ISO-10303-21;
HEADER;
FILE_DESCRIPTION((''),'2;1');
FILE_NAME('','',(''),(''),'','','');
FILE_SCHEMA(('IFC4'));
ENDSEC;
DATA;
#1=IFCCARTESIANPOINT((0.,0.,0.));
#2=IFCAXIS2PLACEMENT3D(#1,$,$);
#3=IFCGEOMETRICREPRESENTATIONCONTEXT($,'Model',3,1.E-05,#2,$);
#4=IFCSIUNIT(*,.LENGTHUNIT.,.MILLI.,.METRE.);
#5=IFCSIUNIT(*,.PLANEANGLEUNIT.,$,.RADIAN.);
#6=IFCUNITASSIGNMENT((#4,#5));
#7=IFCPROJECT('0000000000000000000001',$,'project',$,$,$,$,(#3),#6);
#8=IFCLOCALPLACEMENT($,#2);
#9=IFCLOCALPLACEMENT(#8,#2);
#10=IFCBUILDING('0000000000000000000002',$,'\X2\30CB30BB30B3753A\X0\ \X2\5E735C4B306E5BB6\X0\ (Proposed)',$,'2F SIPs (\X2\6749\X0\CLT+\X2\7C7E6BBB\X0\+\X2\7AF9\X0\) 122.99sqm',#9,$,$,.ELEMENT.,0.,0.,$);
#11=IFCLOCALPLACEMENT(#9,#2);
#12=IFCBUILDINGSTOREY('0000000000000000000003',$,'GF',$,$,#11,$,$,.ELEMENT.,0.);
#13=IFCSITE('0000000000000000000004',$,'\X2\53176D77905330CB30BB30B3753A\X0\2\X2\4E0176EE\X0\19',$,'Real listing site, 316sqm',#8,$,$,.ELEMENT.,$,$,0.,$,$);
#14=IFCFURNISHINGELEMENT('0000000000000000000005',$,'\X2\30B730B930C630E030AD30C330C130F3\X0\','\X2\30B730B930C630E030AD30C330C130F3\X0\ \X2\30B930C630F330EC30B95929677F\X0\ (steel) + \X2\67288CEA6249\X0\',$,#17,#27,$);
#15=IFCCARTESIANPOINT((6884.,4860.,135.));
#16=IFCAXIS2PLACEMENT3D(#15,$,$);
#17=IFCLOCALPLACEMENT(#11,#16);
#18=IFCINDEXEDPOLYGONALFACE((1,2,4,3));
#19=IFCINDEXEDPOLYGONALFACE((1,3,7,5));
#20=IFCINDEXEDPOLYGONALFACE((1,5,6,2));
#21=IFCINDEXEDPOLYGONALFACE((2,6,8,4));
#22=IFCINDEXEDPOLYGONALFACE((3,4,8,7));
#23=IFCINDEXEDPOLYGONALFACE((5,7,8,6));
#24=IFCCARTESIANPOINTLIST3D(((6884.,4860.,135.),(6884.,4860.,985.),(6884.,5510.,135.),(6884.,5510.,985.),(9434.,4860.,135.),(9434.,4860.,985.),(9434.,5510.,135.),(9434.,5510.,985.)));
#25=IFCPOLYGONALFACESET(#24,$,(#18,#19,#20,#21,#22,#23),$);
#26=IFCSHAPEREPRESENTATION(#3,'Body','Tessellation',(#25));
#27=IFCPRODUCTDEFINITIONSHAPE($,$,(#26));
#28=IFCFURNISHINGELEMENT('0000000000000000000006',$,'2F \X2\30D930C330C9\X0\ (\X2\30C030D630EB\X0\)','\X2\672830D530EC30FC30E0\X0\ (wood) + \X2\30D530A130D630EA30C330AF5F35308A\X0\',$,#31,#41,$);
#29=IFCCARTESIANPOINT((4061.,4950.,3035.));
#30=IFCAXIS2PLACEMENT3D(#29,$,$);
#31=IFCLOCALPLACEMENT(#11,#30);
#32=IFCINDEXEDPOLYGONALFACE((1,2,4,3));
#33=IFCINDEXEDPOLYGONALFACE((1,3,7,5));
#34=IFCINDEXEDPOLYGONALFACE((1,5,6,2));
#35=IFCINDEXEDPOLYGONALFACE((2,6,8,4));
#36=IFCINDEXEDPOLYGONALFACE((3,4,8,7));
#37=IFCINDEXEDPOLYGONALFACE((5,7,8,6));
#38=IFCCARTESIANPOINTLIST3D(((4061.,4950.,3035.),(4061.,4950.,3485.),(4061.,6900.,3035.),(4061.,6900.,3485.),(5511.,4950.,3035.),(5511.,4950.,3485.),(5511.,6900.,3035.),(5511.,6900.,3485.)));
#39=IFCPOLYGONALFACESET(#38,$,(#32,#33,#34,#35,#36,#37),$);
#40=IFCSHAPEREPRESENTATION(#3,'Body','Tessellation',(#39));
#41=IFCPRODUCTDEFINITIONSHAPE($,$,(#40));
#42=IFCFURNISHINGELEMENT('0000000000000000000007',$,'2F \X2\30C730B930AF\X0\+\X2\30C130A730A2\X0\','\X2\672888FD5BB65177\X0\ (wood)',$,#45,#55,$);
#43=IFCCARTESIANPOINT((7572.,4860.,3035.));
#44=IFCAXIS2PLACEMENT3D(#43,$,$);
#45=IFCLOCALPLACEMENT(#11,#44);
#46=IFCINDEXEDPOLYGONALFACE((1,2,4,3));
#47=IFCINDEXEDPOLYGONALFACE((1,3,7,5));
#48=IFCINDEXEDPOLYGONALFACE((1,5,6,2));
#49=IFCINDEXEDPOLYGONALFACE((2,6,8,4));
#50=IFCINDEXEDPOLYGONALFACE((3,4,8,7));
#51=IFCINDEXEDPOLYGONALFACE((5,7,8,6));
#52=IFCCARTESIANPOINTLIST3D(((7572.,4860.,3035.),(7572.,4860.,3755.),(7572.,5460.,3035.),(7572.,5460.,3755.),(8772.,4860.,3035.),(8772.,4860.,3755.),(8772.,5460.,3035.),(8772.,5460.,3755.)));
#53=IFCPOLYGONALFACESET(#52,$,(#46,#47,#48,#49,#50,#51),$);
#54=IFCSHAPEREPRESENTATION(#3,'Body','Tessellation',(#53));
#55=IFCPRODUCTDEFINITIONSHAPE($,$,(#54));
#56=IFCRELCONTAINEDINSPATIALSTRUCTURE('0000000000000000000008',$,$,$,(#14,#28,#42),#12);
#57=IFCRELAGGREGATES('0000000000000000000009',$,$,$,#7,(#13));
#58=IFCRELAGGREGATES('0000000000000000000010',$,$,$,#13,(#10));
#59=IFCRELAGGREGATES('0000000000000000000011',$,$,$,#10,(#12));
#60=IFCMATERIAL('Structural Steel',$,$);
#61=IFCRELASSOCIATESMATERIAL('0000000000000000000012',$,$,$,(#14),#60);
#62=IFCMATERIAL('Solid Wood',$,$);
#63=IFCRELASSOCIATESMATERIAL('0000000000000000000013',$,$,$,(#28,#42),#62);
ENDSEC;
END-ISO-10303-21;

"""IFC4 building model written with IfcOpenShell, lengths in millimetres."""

from ifc_helpers import new_model, si_unit, frame, frame_2d, origin, place, context, project, spatial, rectangle, extrude, material, element, save


model = new_model("IFC4")

# Units and contexts
model_context = context("Model", 3, precision=1e-05, world=origin())
ifc_project = project(units=[si_unit("LENGTHUNIT", "METRE", prefix="MILLI"), si_unit("PLANEANGLEUNIT", "RADIAN")], contexts=[model_context])

# Site, building, storey
site_placement = place(None, origin())
site = spatial("IfcSite", under=ifc_project, at=site_placement, Name="北海道ニセコ町2丁目19", ObjectType="Real listing site, 316sqm", CompositionType="ELEMENT", RefElevation=0.0)
building_placement = place(site_placement, origin())
building = spatial("IfcBuilding", under=site, at=building_placement, Name="ニセコ町 平屋の家 (Proposed)", ObjectType="2F SIPs (杉CLT+籾殻+竹) 122.99sqm", CompositionType="ELEMENT", ElevationOfRefHeight=0.0, ElevationOfTerrain=0.0)
storey_placement = place(building_placement, origin())
storey = spatial("IfcBuildingStorey", under=building, at=storey_placement, Name="GF", CompositionType="ELEMENT", Elevation=0.0)

# Shared definitions
ifc_material_1 = material(Name="Solid Wood")

# Furnishing elements
ifc_material_2 = material(Name="Structural Steel")
furnishing_1_placement = place(storey_placement, frame((6884.0, 4860.0, 135.0)))
element("IfcFurnishingElement", 1, at=furnishing_1_placement, inside=storey, material=ifc_material_2, Name="システムキッチン", Description="システムキッチン ステンレス天板 (steel) + 木質扉", context=model_context, shape_type="SweptSolid", body=[
    extrude(rectangle(XDim=2550.0, YDim=650.0, at=frame_2d((1275.0, 325.0))), frame((6884.0, 4860.0, 135.0)), (0.0, 0.0, 1.0), 850.0),
])
furnishing_2_placement = place(storey_placement, frame((4061.0, 4950.0, 3035.0)))
element("IfcFurnishingElement", 2, at=furnishing_2_placement, inside=storey, material=ifc_material_1, Name="2F ベッド (ダブル)", Description="木フレーム (wood) + ファブリック張り", context=model_context, shape_type="SweptSolid", body=[
    extrude(rectangle(XDim=1450.0, YDim=1950.0, at=frame_2d((725.0, 975.0))), frame((4061.0, 4950.0, 3035.0)), (0.0, 0.0, 1.0), 450.0),
])
furnishing_3_placement = place(storey_placement, frame((7572.0, 4860.0, 3035.0)))
element("IfcFurnishingElement", 3, at=furnishing_3_placement, inside=storey, material=ifc_material_1, Name="2F デスク+チェア", Description="木製家具 (wood)", context=model_context, shape_type="SweptSolid", body=[
    extrude(rectangle(XDim=1200.0, YDim=600.0, at=frame_2d((600.0, 300.0))), frame((7572.0, 4860.0, 3035.0)), (0.0, 0.0, 1.0), 720.0),
])

save(model, "model.ifc")
